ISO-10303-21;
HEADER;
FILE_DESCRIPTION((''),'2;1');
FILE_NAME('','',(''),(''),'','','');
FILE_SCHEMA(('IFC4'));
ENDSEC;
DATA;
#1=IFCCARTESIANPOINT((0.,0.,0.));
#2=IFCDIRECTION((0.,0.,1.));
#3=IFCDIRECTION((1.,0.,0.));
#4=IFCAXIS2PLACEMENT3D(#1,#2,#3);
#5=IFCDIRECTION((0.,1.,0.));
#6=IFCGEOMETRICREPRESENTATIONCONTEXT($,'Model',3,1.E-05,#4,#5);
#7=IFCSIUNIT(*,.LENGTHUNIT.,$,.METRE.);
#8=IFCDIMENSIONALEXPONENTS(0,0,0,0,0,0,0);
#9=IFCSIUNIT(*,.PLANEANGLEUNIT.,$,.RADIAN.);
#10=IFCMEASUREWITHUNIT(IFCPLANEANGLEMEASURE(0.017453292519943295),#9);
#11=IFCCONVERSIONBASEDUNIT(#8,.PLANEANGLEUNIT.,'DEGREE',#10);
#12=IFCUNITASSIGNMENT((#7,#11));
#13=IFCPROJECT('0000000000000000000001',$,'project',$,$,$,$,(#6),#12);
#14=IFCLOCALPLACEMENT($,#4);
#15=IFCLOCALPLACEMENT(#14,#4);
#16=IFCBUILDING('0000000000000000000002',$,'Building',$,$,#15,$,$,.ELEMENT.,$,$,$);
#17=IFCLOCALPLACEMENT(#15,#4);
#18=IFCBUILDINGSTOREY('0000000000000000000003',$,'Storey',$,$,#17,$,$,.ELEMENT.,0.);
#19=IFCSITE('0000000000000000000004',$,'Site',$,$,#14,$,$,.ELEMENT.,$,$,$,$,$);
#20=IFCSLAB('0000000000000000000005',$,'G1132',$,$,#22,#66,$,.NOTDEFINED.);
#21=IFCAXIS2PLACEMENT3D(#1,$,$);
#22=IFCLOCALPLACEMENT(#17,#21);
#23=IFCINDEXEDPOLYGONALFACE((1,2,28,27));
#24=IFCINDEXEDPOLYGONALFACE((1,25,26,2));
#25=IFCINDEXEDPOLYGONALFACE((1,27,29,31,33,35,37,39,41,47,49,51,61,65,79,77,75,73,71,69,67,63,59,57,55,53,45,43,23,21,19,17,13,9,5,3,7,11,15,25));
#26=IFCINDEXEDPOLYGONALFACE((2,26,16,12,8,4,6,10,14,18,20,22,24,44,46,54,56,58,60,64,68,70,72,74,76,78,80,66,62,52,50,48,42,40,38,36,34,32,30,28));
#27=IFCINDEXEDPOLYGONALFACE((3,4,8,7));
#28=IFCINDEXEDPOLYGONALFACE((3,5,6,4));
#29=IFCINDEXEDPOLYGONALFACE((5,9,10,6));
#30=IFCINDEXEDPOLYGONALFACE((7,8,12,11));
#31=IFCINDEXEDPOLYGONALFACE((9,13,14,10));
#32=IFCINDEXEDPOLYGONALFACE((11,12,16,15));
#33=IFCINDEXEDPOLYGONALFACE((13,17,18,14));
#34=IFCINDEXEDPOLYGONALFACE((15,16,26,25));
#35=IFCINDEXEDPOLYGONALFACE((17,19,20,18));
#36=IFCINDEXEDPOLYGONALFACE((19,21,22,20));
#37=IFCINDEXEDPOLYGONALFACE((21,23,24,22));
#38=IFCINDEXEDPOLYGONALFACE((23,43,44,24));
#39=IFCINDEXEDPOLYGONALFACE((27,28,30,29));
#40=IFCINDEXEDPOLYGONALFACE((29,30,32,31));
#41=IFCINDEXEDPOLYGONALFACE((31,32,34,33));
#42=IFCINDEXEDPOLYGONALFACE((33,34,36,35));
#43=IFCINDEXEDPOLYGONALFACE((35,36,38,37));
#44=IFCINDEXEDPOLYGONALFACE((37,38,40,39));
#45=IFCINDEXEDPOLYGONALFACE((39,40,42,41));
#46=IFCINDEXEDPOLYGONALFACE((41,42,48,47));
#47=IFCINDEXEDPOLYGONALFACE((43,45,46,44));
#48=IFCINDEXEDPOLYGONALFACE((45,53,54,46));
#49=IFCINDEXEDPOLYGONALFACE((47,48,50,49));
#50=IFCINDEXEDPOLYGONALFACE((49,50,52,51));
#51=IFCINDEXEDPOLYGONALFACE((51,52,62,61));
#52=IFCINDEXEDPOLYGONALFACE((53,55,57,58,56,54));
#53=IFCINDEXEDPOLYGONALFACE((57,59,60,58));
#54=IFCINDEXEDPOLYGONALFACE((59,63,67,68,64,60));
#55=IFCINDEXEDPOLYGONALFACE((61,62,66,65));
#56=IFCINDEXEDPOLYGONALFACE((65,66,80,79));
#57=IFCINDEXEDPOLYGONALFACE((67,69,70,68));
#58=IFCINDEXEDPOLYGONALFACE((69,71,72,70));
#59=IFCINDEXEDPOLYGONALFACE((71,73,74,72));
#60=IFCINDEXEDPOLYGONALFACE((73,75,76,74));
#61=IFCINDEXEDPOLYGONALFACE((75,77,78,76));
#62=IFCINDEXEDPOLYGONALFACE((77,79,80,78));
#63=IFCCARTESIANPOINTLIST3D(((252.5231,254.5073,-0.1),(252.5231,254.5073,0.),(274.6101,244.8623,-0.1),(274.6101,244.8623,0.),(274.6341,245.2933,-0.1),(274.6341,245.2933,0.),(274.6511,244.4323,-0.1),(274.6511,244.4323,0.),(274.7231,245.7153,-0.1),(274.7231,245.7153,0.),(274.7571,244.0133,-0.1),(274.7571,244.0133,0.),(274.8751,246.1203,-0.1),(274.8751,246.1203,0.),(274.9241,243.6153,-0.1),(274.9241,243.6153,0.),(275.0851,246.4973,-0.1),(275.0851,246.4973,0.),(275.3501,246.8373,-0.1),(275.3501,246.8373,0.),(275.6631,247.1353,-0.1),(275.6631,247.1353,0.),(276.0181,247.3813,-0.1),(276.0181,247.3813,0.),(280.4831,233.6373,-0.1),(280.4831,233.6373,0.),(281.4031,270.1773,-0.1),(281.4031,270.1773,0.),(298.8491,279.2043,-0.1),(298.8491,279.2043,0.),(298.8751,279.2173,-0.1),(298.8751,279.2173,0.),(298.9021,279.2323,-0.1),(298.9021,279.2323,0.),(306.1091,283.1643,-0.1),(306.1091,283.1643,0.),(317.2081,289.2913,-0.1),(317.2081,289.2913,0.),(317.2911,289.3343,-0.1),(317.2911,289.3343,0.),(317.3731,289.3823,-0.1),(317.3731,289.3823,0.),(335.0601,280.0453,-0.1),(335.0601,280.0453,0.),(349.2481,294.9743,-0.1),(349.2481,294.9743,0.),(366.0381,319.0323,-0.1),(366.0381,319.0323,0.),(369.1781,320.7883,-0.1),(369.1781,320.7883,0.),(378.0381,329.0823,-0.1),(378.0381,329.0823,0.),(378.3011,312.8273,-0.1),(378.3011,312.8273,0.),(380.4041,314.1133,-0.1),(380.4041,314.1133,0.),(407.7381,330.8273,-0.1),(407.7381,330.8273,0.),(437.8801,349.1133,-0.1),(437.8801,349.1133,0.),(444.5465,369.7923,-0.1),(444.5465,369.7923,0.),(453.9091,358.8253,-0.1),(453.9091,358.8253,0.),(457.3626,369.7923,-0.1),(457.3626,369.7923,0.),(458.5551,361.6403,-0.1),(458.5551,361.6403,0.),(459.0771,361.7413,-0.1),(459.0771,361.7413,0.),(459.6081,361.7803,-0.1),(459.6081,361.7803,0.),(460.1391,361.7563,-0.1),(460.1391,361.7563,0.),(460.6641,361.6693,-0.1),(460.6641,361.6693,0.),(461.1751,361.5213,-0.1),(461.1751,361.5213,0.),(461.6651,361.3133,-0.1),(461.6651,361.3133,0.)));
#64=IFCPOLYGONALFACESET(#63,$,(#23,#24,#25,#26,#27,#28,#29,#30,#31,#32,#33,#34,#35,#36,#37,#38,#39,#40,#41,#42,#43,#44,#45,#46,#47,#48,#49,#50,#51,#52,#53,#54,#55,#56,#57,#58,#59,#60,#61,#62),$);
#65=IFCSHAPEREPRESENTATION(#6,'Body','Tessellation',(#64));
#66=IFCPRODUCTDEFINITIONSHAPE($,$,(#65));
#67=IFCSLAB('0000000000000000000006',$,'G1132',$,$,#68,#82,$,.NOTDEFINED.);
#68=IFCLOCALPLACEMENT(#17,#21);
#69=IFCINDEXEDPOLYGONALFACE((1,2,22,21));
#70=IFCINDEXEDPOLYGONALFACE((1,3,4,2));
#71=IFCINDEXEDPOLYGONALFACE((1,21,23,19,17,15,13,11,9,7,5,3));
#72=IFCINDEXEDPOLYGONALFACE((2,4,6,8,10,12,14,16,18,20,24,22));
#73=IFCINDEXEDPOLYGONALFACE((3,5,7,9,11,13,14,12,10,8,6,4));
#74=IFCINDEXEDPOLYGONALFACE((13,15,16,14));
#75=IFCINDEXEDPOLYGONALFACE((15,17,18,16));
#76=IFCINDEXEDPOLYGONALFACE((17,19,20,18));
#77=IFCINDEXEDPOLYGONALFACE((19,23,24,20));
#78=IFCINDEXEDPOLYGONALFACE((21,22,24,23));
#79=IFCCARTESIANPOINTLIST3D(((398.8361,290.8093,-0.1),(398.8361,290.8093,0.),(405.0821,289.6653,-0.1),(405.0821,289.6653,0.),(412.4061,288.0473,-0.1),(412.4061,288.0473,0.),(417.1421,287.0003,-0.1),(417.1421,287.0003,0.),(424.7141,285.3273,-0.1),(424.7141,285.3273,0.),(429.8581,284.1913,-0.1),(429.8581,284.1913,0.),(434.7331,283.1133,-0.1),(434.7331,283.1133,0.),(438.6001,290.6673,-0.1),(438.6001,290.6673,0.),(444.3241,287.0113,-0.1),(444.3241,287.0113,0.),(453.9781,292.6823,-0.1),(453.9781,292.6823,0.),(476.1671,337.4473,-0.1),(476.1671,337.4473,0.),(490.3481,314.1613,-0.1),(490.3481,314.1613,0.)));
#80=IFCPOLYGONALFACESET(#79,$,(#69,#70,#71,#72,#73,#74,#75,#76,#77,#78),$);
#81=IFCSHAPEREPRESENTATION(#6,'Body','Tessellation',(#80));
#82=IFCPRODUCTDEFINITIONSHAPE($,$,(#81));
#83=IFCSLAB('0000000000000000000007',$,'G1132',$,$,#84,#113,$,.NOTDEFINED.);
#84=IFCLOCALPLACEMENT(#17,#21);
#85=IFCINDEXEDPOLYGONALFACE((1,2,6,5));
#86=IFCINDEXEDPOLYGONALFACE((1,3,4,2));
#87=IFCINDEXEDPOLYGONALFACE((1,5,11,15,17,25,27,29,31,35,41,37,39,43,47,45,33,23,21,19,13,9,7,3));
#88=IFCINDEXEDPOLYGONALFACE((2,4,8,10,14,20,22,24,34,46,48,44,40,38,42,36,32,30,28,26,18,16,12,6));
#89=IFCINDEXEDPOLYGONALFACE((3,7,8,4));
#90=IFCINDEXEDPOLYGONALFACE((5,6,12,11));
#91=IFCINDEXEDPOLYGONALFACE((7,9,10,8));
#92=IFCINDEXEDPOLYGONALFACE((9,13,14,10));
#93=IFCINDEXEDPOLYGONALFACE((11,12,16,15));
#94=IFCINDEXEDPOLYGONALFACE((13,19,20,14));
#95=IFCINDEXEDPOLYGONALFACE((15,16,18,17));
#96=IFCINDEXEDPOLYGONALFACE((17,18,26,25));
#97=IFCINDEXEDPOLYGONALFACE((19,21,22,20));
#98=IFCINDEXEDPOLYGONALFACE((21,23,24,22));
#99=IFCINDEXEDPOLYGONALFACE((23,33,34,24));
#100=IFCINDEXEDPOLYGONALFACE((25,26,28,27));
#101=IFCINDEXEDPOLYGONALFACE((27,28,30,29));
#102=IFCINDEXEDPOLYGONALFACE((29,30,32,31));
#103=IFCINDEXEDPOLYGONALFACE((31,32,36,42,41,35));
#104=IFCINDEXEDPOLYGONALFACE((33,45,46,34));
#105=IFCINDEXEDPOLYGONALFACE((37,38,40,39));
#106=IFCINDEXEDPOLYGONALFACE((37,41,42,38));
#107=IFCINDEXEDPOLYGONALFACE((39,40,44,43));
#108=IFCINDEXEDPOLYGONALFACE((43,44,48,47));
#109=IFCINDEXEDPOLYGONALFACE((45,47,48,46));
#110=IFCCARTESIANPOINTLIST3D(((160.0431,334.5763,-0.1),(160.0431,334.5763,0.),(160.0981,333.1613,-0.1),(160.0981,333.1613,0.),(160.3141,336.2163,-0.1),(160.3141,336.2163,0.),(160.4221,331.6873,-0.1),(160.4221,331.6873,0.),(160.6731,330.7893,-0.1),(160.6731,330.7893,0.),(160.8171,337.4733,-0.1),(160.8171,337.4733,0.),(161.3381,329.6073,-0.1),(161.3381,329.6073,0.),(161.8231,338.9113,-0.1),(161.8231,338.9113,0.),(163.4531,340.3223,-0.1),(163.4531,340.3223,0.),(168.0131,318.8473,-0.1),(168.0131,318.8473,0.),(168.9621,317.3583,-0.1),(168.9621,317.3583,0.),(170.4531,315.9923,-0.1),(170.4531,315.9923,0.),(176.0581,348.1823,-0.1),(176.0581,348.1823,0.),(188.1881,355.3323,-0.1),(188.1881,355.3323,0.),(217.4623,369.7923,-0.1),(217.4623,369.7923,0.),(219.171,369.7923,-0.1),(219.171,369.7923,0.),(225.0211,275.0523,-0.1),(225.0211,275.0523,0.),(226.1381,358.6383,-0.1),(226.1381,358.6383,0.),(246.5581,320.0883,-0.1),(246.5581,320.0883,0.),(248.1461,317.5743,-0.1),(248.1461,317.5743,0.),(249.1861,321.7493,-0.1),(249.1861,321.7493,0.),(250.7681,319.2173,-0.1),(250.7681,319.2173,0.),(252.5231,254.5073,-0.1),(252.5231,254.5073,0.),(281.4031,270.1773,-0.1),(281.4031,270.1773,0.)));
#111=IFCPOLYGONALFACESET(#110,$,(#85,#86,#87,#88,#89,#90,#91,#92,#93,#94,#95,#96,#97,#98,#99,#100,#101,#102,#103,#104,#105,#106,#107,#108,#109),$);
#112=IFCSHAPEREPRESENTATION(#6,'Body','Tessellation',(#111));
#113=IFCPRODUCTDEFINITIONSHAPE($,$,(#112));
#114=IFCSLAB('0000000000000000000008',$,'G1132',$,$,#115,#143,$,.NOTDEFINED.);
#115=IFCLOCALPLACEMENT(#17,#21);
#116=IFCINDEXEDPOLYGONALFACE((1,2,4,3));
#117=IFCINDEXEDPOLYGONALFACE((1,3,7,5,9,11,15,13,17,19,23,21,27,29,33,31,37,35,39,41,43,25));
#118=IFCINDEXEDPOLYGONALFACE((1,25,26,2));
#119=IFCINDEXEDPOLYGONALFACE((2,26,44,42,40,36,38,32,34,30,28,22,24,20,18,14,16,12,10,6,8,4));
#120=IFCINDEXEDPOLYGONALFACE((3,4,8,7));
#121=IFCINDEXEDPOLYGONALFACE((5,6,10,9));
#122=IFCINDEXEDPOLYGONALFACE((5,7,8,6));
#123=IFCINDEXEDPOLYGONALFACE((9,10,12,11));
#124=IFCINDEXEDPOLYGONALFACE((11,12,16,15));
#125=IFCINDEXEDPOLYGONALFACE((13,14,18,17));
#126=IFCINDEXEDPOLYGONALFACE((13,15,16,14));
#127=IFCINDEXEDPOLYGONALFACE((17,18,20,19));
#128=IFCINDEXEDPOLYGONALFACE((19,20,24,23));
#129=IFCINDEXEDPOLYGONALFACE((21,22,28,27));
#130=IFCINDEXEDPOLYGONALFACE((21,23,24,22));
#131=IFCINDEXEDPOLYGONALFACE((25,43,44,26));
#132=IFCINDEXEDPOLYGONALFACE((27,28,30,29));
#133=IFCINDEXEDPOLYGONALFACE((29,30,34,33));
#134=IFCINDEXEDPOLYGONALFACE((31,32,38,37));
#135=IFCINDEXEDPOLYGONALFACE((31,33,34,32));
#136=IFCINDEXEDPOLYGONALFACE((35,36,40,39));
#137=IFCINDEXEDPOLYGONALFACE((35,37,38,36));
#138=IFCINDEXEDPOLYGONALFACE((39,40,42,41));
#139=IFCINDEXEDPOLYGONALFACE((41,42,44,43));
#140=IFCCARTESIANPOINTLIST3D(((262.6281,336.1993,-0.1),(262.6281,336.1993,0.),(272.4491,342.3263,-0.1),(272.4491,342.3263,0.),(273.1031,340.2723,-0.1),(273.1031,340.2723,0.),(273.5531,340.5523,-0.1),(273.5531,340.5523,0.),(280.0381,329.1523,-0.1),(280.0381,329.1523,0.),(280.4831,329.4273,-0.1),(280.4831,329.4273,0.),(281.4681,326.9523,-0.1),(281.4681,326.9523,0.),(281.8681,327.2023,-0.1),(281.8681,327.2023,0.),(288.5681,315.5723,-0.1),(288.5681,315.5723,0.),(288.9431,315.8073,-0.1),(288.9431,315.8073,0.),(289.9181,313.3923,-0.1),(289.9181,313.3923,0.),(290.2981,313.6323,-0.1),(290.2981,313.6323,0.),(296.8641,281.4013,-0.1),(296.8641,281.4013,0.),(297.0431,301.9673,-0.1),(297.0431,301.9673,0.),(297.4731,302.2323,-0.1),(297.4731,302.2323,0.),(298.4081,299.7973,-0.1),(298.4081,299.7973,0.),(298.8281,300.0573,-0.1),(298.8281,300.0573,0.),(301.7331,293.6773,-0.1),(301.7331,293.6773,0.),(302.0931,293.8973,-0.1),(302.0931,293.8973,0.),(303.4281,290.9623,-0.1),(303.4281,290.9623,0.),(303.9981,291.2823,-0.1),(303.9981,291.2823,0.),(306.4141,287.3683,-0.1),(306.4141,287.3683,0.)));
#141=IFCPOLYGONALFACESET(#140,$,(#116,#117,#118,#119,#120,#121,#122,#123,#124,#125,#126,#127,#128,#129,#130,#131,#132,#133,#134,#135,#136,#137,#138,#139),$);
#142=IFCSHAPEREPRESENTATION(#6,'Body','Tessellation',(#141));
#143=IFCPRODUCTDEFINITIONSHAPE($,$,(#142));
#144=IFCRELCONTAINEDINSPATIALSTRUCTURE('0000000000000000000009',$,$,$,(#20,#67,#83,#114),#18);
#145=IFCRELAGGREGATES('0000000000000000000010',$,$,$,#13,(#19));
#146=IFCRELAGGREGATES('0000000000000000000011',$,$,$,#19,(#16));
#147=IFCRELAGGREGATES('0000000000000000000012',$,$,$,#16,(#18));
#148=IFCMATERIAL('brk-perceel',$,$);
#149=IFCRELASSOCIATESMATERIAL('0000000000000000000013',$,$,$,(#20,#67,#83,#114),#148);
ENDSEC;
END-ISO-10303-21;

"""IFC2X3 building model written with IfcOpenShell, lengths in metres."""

from ifc_helpers import new_model, entity, si_unit, converted_unit, direction, frame, origin_with_axes, place, context, project, spatial, polyline, outline, extrude, material, element, save


model = new_model("IFC2X3")

# Units and contexts
model_context = context("Model", 3, precision=1e-05, world=origin_with_axes(), true_north=direction((0.0, 1.0, 0.0)))
ifc_project = project(units=[si_unit("LENGTHUNIT", "METRE"), converted_unit("PLANEANGLEUNIT", "DEGREE", entity("IfcPlaneAngleMeasure", 0.017453292519943295), si_unit("PLANEANGLEUNIT", "RADIAN"), dimensions=[0, 0, 0, 0, 0, 0, 0])], contexts=[model_context])

# Site, building, storey
site_placement = place(None, origin_with_axes())
site = spatial("IfcSite", under=ifc_project, at=site_placement, Name="Site", CompositionType="ELEMENT")
building_placement = place(site_placement, origin_with_axes())
building = spatial("IfcBuilding", under=site, at=building_placement, Name="Building", CompositionType="ELEMENT")
storey_placement = place(building_placement, origin_with_axes())
storey = spatial("IfcBuildingStorey", under=building, at=storey_placement, Name="Storey", CompositionType="ELEMENT", Elevation=0.0)

# Slabs
ifc_material = material(Name="brk-perceel")
slab_1_placement = place(storey_placement, frame((0.0, 0.0, -0.1), z_axis=(0.0, 0.0, 1.0), x_axis=(1.0, 0.0, 0.0)))
element("IfcSlab", 1, at=slab_1_placement, inside=storey, material=ifc_material, Name="G1132", PredefinedType="NOTDEFINED", context=model_context, shape_type="SweptSolid", body=[
    extrude(outline(polyline([(461.6651, 361.3133), (461.1751, 361.5213), (460.6641, 361.6693), (460.1391, 361.7563), (459.6081, 361.7803), (459.0771, 361.7413), (458.5551, 361.6403), (453.9091, 358.8253), (437.8801, 349.1133), (407.7381, 330.8273), (380.4041, 314.1133), (378.3011, 312.8273), (349.2481, 294.9743), (335.0601, 280.0453), (276.0181, 247.3813), (275.6631, 247.1353), (275.3501, 246.8373), (275.0851, 246.4973), (274.8751, 246.1203), (274.7231, 245.7153), (274.6341, 245.2933), (274.6101, 244.8623), (274.6511, 244.4323), (274.7571, 244.0133), (274.9241, 243.6153), (280.4831, 233.6373), (252.5231, 254.5073), (281.4031, 270.1773), (298.8491, 279.2043), (298.8751, 279.2173), (298.9021, 279.2323), (306.1091, 283.1643), (317.2081, 289.2913), (317.2911, 289.3343), (317.3731, 289.3823), (366.0381, 319.0323), (369.1781, 320.7883), (378.0381, 329.0823), (444.5465, 369.7923), (457.3626, 369.7923), (461.6651, 361.3133)])), origin_with_axes(), (0.0, 0.0, 1.0), 0.1),
])
slab_2_placement = place(storey_placement, frame((0.0, 0.0, -0.1), z_axis=(0.0, 0.0, 1.0), x_axis=(1.0, 0.0, 0.0)))
element("IfcSlab", 2, at=slab_2_placement, inside=storey, material=ifc_material, Name="G1132", PredefinedType="NOTDEFINED", context=model_context, shape_type="SweptSolid", body=[
    extrude(outline(polyline([(438.6001, 290.6673), (434.7331, 283.1133), (429.8581, 284.1913), (424.7141, 285.3273), (417.1421, 287.0003), (412.4061, 288.0473), (405.0821, 289.6653), (398.8361, 290.8093), (476.1671, 337.4473), (490.3481, 314.1613), (453.9781, 292.6823), (444.3241, 287.0113), (438.6001, 290.6673)])), origin_with_axes(), (0.0, 0.0, 1.0), 0.1),
])
slab_3_placement = place(storey_placement, frame((0.0, 0.0, -0.1), z_axis=(0.0, 0.0, 1.0), x_axis=(1.0, 0.0, 0.0)))
element("IfcSlab", 3, at=slab_3_placement, inside=storey, material=ifc_material, Name="G1132", PredefinedType="NOTDEFINED", context=model_context, shape_type="SweptSolid", body=[
    extrude(outline(polyline([(226.1381, 358.6383), (249.1861, 321.7493), (246.5581, 320.0883), (248.1461, 317.5743), (250.7681, 319.2173), (281.4031, 270.1773), (252.5231, 254.5073), (225.0211, 275.0523), (170.4531, 315.9923), (168.9621, 317.3583), (168.0131, 318.8473), (161.3381, 329.6073), (160.6731, 330.7893), (160.4221, 331.6873), (160.0981, 333.1613), (160.0431, 334.5763), (160.3141, 336.2163), (160.8171, 337.4733), (161.8231, 338.9113), (163.4531, 340.3223), (176.0581, 348.1823), (188.1881, 355.3323), (217.4623, 369.7923), (219.171, 369.7923), (226.1381, 358.6383)])), origin_with_axes(), (0.0, 0.0, 1.0), 0.1),
])
slab_4_placement = place(storey_placement, frame((0.0, 0.0, -0.1), z_axis=(0.0, 0.0, 1.0), x_axis=(1.0, 0.0, 0.0)))
element("IfcSlab", 4, at=slab_4_placement, inside=storey, material=ifc_material, Name="G1132", PredefinedType="NOTDEFINED", context=model_context, shape_type="SweptSolid", body=[
    extrude(outline(polyline([(296.8641, 281.4013), (262.6281, 336.1993), (272.4491, 342.3263), (273.5531, 340.5523), (273.1031, 340.2723), (280.0381, 329.1523), (280.4831, 329.4273), (281.8681, 327.2023), (281.4681, 326.9523), (288.5681, 315.5723), (288.9431, 315.8073), (290.2981, 313.6323), (289.9181, 313.3923), (297.0431, 301.9673), (297.4731, 302.2323), (298.8281, 300.0573), (298.4081, 299.7973), (302.0931, 293.8973), (301.7331, 293.6773), (303.4281, 290.9623), (303.9981, 291.2823), (306.4141, 287.3683), (296.8641, 281.4013)])), origin_with_axes(), (0.0, 0.0, 1.0), 0.1),
])

save(model, "model.ifc")
